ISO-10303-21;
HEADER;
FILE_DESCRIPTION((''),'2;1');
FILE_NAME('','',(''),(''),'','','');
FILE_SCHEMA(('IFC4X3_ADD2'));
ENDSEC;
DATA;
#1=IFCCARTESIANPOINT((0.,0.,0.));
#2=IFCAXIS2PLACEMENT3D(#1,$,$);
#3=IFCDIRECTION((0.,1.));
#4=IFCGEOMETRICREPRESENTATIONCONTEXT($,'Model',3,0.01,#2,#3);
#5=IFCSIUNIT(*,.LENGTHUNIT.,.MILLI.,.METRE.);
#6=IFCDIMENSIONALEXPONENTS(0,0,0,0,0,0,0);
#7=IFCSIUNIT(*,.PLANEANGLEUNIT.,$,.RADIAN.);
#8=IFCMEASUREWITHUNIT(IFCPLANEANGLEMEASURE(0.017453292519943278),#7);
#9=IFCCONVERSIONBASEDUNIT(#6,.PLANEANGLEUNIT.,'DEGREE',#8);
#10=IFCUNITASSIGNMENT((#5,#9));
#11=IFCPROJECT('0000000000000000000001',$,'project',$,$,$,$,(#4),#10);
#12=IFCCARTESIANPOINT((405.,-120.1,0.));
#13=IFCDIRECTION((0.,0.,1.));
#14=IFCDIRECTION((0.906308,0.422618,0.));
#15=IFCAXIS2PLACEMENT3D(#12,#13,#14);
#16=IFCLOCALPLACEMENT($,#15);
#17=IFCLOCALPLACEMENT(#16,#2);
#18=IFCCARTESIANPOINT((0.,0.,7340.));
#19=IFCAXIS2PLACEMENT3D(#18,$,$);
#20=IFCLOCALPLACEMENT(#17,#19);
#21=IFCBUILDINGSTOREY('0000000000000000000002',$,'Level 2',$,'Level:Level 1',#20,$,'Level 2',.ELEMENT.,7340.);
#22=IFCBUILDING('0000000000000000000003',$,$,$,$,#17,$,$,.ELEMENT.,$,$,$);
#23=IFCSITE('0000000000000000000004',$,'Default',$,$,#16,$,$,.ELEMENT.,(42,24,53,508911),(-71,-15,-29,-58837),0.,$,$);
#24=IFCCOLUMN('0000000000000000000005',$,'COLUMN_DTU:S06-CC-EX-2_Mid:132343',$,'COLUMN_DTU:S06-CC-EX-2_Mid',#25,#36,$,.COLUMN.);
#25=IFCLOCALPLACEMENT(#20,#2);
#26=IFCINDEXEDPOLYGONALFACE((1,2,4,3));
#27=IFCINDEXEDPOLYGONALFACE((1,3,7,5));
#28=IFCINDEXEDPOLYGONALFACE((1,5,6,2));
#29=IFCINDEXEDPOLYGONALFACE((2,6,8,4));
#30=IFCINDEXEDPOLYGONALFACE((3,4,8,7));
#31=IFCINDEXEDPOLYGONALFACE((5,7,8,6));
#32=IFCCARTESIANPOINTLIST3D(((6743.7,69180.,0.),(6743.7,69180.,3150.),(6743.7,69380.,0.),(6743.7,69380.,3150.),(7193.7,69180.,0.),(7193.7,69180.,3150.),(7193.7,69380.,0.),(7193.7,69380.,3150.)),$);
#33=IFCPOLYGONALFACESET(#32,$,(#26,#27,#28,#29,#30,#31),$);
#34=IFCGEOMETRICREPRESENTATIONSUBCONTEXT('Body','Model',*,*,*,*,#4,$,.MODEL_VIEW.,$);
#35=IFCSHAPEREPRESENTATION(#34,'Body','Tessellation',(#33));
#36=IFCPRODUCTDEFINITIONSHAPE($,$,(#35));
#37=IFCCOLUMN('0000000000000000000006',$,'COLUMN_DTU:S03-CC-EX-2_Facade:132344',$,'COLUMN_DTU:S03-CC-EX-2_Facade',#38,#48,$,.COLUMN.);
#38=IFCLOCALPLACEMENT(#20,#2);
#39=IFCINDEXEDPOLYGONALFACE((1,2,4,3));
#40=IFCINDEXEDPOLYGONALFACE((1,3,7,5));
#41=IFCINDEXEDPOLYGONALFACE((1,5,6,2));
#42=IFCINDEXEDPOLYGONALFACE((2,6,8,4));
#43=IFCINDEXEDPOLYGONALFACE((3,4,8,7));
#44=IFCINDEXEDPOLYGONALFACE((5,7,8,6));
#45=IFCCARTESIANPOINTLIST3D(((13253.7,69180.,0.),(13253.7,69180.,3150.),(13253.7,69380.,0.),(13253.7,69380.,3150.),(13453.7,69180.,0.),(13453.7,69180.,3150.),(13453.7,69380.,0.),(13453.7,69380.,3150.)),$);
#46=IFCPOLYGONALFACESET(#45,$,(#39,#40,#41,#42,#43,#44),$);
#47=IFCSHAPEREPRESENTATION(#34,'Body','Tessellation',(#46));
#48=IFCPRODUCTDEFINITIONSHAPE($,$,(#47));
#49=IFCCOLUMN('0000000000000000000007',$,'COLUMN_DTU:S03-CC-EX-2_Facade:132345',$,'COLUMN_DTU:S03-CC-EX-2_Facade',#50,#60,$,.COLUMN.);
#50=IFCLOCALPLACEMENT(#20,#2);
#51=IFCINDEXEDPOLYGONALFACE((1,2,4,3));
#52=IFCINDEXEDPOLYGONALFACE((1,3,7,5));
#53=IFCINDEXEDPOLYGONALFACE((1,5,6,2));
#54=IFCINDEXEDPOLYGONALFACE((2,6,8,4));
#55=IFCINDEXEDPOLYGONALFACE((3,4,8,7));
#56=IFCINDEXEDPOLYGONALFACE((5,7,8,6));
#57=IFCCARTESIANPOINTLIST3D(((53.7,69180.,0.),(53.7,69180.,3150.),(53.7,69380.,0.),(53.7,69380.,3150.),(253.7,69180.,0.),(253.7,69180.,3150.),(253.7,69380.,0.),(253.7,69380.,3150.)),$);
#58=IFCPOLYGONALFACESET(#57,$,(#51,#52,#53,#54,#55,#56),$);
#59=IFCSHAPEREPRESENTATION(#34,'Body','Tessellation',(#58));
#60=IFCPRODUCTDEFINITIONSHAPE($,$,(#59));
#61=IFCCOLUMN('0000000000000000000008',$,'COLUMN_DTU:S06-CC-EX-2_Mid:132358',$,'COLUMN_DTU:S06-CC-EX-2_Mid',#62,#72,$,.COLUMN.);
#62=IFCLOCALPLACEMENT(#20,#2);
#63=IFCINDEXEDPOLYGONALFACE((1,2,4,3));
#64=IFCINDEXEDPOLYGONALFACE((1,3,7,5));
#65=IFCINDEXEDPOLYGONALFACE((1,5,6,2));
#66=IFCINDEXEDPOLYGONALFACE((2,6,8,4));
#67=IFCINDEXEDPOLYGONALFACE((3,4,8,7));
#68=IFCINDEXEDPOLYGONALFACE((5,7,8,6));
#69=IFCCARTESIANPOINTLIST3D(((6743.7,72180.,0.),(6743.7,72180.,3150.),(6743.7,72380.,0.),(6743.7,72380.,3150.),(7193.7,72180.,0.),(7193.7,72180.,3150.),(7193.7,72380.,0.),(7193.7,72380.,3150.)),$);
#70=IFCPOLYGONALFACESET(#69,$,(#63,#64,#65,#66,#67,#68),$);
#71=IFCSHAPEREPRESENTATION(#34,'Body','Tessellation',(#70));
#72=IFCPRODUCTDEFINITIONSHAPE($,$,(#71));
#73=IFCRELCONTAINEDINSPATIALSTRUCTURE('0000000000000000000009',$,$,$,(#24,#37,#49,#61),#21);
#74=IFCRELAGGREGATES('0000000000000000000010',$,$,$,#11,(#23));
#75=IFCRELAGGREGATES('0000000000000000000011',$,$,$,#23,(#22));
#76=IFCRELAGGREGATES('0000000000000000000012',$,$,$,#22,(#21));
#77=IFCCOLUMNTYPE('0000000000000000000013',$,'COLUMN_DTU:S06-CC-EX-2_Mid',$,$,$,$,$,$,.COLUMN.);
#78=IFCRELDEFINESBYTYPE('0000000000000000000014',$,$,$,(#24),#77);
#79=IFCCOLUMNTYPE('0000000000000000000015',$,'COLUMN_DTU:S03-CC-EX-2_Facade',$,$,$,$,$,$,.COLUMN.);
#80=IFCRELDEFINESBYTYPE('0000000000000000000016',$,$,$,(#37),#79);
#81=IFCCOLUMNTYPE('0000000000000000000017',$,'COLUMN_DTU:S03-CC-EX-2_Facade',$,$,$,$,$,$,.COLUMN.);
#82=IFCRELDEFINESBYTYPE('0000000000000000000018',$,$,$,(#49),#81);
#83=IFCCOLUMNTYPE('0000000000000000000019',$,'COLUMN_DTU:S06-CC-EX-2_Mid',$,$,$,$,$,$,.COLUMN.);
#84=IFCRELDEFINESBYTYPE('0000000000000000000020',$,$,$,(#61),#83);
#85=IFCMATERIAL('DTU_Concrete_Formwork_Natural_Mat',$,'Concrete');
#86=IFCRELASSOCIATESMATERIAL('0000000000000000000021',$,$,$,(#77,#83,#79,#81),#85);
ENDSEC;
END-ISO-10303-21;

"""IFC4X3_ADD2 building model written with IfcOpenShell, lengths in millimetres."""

from ifc_helpers import new_model, entity, si_unit, converted_unit, direction, frame, frame_2d, origin, origin_2d_with_axis, place, context, subcontext, project, spatial, rectangle, extrude, source, transform, mapped, material, material_profile, profile_set, type_object, type_shapes, element, save


model = new_model("IFC4X3_ADD2")

# Units and contexts
model_context = context("Model", 3, precision=0.01, world=origin(), true_north=direction((0.0, 1.0)))
body_context = subcontext(model_context, "Body", "Model", "MODEL_VIEW")
ifc_project = project(units=[si_unit("LENGTHUNIT", "METRE", prefix="MILLI"), converted_unit("PLANEANGLEUNIT", "DEGREE", entity("IfcPlaneAngleMeasure", 0.017453292519943278), si_unit("PLANEANGLEUNIT", "RADIAN"), dimensions=[0, 0, 0, 0, 0, 0, 0])], contexts=[model_context])

# Site, building, storey
site_placement = place(None, frame((405.0, -120.1, 0.0), z_axis=(0.0, 0.0, 1.0), x_axis=(0.906308, 0.422618, 0.0)))
site = spatial("IfcSite", under=ifc_project, at=site_placement, Name="Default", CompositionType="ELEMENT", RefLatitude=(42, 24, 53, 508911), RefLongitude=(-71, -15, -29, -58837), RefElevation=0.0)
building_placement = place(site_placement, origin())
building = spatial("IfcBuilding", under=site, at=building_placement, CompositionType="ELEMENT")
storey_placement = place(building_placement, frame((0.0, 0.0, 7340.0)))
storey = spatial("IfcBuildingStorey", under=building, at=storey_placement, Name="Level 2", ObjectType="Level:Level 1", LongName="Level 2", CompositionType="ELEMENT", Elevation=7340.0)

# Columns
ifc_material = material(Name="DTU_Concrete_Formwork_Natural_Mat", Category="Concrete")
ifc_material_profile_1 = material_profile(ifc_material, rectangle(XDim=200.0, YDim=450.0, at=origin_2d_with_axis()), Name="S06-CC-EX-2_Mid")
ifc_profile_set_1 = profile_set([ifc_material_profile_1], Name="S06-CC-EX-2_Mid")
ifc_material_profile_2 = material_profile(ifc_material, rectangle(XDim=200.0, YDim=200.0, at=frame_2d((0.0, 0.0), x_axis=(1.0, 0.0))), Name="S03-CC-EX-2_Facade")
ifc_profile_set_2 = profile_set([ifc_material_profile_2], Name="S03-CC-EX-2_Facade")
column_type_1 = type_object("IfcColumnType", Name="COLUMN_DTU:S06-CC-EX-2_Mid", PredefinedType="COLUMN", material=ifc_profile_set_1)
shared_shape_1 = source(origin(), body_context, "Body", "SweptSolid", [
    extrude(rectangle(XDim=200.0, YDim=450.0, at=frame_2d((0.0, 0.0), x_axis=(1.0, 0.0))), frame((6968.7, 69280.0, 7340.0), z_axis=(0.0, 0.0, 1.0), x_axis=(0.0, 1.0, 0.0)), (0.0, 0.0, 1.0), 3150.0),
])
type_shapes(column_type_1, [shared_shape_1])
column_1_placement = place(storey_placement, frame((0.0, 0.0, -7340.0)))
element("IfcColumn", 1, at=column_1_placement, inside=storey, type_object=column_type_1, Name="COLUMN_DTU:S06-CC-EX-2_Mid:132343", ObjectType="COLUMN_DTU:S06-CC-EX-2_Mid", PredefinedType="COLUMN", context=body_context, shape_type="MappedRepresentation", body=[
    mapped(shared_shape_1, transform((0.0, 0.0, 0.0), scale=1.0)),
])
column_type_2 = type_object("IfcColumnType", Name="COLUMN_DTU:S03-CC-EX-2_Facade", PredefinedType="COLUMN", material=ifc_profile_set_2)
shared_shape_2 = source(origin(), body_context, "Body", "SweptSolid", [
    extrude(rectangle(XDim=200.0, YDim=200.0, at=frame_2d((0.0, 0.0), x_axis=(1.0, 0.0))), frame((13353.7, 69280.0, 7340.0), z_axis=(0.0, 0.0, 1.0), x_axis=(0.0, -1.0, 0.0)), (0.0, 0.0, 1.0), 3150.0),
])
type_shapes(column_type_2, [shared_shape_2])
column_2_placement = place(storey_placement, frame((0.0, 0.0, -7340.0)))
element("IfcColumn", 2, at=column_2_placement, inside=storey, type_object=column_type_2, Name="COLUMN_DTU:S03-CC-EX-2_Facade:132344", ObjectType="COLUMN_DTU:S03-CC-EX-2_Facade", PredefinedType="COLUMN", context=body_context, shape_type="MappedRepresentation", body=[
    mapped(shared_shape_2, transform((0.0, 0.0, 0.0), scale=1.0)),
])
column_type_3 = type_object("IfcColumnType", Name="COLUMN_DTU:S03-CC-EX-2_Facade", PredefinedType="COLUMN", material=ifc_profile_set_2)
shared_shape_3 = source(origin(), body_context, "Body", "SweptSolid", [
    extrude(rectangle(XDim=200.0, YDim=200.0, at=frame_2d((0.0, 0.0), x_axis=(1.0, 0.0))), frame((153.7, 69280.0, 7340.0), z_axis=(0.0, 0.0, 1.0), x_axis=(0.0, -1.0, 0.0)), (0.0, 0.0, 1.0), 3150.0),
])
type_shapes(column_type_3, [shared_shape_3])
column_3_placement = place(storey_placement, frame((0.0, 0.0, -7340.0)))
element("IfcColumn", 3, at=column_3_placement, inside=storey, type_object=column_type_3, Name="COLUMN_DTU:S03-CC-EX-2_Facade:132345", ObjectType="COLUMN_DTU:S03-CC-EX-2_Facade", PredefinedType="COLUMN", context=body_context, shape_type="MappedRepresentation", body=[
    mapped(shared_shape_3, transform((0.0, 0.0, 0.0), scale=1.0)),
])
column_type_4 = type_object("IfcColumnType", Name="COLUMN_DTU:S06-CC-EX-2_Mid", PredefinedType="COLUMN", material=ifc_profile_set_1)
shared_shape_4 = source(origin(), body_context, "Body", "SweptSolid", [
    extrude(rectangle(XDim=200.0, YDim=450.0, at=frame_2d((0.0, 0.0), x_axis=(1.0, 0.0))), frame((6968.7, 72280.0, 7340.0), z_axis=(0.0, 0.0, 1.0), x_axis=(0.0, 1.0, 0.0)), (0.0, 0.0, 1.0), 3150.0),
])
type_shapes(column_type_4, [shared_shape_4])
column_4_placement = place(storey_placement, frame((0.0, 0.0, -7340.0)))
element("IfcColumn", 4, at=column_4_placement, inside=storey, type_object=column_type_4, Name="COLUMN_DTU:S06-CC-EX-2_Mid:132358", ObjectType="COLUMN_DTU:S06-CC-EX-2_Mid", PredefinedType="COLUMN", context=body_context, shape_type="MappedRepresentation", body=[
    mapped(shared_shape_4, transform((0.0, 0.0, 0.0), scale=1.0)),
])

save(model, "model.ifc")
